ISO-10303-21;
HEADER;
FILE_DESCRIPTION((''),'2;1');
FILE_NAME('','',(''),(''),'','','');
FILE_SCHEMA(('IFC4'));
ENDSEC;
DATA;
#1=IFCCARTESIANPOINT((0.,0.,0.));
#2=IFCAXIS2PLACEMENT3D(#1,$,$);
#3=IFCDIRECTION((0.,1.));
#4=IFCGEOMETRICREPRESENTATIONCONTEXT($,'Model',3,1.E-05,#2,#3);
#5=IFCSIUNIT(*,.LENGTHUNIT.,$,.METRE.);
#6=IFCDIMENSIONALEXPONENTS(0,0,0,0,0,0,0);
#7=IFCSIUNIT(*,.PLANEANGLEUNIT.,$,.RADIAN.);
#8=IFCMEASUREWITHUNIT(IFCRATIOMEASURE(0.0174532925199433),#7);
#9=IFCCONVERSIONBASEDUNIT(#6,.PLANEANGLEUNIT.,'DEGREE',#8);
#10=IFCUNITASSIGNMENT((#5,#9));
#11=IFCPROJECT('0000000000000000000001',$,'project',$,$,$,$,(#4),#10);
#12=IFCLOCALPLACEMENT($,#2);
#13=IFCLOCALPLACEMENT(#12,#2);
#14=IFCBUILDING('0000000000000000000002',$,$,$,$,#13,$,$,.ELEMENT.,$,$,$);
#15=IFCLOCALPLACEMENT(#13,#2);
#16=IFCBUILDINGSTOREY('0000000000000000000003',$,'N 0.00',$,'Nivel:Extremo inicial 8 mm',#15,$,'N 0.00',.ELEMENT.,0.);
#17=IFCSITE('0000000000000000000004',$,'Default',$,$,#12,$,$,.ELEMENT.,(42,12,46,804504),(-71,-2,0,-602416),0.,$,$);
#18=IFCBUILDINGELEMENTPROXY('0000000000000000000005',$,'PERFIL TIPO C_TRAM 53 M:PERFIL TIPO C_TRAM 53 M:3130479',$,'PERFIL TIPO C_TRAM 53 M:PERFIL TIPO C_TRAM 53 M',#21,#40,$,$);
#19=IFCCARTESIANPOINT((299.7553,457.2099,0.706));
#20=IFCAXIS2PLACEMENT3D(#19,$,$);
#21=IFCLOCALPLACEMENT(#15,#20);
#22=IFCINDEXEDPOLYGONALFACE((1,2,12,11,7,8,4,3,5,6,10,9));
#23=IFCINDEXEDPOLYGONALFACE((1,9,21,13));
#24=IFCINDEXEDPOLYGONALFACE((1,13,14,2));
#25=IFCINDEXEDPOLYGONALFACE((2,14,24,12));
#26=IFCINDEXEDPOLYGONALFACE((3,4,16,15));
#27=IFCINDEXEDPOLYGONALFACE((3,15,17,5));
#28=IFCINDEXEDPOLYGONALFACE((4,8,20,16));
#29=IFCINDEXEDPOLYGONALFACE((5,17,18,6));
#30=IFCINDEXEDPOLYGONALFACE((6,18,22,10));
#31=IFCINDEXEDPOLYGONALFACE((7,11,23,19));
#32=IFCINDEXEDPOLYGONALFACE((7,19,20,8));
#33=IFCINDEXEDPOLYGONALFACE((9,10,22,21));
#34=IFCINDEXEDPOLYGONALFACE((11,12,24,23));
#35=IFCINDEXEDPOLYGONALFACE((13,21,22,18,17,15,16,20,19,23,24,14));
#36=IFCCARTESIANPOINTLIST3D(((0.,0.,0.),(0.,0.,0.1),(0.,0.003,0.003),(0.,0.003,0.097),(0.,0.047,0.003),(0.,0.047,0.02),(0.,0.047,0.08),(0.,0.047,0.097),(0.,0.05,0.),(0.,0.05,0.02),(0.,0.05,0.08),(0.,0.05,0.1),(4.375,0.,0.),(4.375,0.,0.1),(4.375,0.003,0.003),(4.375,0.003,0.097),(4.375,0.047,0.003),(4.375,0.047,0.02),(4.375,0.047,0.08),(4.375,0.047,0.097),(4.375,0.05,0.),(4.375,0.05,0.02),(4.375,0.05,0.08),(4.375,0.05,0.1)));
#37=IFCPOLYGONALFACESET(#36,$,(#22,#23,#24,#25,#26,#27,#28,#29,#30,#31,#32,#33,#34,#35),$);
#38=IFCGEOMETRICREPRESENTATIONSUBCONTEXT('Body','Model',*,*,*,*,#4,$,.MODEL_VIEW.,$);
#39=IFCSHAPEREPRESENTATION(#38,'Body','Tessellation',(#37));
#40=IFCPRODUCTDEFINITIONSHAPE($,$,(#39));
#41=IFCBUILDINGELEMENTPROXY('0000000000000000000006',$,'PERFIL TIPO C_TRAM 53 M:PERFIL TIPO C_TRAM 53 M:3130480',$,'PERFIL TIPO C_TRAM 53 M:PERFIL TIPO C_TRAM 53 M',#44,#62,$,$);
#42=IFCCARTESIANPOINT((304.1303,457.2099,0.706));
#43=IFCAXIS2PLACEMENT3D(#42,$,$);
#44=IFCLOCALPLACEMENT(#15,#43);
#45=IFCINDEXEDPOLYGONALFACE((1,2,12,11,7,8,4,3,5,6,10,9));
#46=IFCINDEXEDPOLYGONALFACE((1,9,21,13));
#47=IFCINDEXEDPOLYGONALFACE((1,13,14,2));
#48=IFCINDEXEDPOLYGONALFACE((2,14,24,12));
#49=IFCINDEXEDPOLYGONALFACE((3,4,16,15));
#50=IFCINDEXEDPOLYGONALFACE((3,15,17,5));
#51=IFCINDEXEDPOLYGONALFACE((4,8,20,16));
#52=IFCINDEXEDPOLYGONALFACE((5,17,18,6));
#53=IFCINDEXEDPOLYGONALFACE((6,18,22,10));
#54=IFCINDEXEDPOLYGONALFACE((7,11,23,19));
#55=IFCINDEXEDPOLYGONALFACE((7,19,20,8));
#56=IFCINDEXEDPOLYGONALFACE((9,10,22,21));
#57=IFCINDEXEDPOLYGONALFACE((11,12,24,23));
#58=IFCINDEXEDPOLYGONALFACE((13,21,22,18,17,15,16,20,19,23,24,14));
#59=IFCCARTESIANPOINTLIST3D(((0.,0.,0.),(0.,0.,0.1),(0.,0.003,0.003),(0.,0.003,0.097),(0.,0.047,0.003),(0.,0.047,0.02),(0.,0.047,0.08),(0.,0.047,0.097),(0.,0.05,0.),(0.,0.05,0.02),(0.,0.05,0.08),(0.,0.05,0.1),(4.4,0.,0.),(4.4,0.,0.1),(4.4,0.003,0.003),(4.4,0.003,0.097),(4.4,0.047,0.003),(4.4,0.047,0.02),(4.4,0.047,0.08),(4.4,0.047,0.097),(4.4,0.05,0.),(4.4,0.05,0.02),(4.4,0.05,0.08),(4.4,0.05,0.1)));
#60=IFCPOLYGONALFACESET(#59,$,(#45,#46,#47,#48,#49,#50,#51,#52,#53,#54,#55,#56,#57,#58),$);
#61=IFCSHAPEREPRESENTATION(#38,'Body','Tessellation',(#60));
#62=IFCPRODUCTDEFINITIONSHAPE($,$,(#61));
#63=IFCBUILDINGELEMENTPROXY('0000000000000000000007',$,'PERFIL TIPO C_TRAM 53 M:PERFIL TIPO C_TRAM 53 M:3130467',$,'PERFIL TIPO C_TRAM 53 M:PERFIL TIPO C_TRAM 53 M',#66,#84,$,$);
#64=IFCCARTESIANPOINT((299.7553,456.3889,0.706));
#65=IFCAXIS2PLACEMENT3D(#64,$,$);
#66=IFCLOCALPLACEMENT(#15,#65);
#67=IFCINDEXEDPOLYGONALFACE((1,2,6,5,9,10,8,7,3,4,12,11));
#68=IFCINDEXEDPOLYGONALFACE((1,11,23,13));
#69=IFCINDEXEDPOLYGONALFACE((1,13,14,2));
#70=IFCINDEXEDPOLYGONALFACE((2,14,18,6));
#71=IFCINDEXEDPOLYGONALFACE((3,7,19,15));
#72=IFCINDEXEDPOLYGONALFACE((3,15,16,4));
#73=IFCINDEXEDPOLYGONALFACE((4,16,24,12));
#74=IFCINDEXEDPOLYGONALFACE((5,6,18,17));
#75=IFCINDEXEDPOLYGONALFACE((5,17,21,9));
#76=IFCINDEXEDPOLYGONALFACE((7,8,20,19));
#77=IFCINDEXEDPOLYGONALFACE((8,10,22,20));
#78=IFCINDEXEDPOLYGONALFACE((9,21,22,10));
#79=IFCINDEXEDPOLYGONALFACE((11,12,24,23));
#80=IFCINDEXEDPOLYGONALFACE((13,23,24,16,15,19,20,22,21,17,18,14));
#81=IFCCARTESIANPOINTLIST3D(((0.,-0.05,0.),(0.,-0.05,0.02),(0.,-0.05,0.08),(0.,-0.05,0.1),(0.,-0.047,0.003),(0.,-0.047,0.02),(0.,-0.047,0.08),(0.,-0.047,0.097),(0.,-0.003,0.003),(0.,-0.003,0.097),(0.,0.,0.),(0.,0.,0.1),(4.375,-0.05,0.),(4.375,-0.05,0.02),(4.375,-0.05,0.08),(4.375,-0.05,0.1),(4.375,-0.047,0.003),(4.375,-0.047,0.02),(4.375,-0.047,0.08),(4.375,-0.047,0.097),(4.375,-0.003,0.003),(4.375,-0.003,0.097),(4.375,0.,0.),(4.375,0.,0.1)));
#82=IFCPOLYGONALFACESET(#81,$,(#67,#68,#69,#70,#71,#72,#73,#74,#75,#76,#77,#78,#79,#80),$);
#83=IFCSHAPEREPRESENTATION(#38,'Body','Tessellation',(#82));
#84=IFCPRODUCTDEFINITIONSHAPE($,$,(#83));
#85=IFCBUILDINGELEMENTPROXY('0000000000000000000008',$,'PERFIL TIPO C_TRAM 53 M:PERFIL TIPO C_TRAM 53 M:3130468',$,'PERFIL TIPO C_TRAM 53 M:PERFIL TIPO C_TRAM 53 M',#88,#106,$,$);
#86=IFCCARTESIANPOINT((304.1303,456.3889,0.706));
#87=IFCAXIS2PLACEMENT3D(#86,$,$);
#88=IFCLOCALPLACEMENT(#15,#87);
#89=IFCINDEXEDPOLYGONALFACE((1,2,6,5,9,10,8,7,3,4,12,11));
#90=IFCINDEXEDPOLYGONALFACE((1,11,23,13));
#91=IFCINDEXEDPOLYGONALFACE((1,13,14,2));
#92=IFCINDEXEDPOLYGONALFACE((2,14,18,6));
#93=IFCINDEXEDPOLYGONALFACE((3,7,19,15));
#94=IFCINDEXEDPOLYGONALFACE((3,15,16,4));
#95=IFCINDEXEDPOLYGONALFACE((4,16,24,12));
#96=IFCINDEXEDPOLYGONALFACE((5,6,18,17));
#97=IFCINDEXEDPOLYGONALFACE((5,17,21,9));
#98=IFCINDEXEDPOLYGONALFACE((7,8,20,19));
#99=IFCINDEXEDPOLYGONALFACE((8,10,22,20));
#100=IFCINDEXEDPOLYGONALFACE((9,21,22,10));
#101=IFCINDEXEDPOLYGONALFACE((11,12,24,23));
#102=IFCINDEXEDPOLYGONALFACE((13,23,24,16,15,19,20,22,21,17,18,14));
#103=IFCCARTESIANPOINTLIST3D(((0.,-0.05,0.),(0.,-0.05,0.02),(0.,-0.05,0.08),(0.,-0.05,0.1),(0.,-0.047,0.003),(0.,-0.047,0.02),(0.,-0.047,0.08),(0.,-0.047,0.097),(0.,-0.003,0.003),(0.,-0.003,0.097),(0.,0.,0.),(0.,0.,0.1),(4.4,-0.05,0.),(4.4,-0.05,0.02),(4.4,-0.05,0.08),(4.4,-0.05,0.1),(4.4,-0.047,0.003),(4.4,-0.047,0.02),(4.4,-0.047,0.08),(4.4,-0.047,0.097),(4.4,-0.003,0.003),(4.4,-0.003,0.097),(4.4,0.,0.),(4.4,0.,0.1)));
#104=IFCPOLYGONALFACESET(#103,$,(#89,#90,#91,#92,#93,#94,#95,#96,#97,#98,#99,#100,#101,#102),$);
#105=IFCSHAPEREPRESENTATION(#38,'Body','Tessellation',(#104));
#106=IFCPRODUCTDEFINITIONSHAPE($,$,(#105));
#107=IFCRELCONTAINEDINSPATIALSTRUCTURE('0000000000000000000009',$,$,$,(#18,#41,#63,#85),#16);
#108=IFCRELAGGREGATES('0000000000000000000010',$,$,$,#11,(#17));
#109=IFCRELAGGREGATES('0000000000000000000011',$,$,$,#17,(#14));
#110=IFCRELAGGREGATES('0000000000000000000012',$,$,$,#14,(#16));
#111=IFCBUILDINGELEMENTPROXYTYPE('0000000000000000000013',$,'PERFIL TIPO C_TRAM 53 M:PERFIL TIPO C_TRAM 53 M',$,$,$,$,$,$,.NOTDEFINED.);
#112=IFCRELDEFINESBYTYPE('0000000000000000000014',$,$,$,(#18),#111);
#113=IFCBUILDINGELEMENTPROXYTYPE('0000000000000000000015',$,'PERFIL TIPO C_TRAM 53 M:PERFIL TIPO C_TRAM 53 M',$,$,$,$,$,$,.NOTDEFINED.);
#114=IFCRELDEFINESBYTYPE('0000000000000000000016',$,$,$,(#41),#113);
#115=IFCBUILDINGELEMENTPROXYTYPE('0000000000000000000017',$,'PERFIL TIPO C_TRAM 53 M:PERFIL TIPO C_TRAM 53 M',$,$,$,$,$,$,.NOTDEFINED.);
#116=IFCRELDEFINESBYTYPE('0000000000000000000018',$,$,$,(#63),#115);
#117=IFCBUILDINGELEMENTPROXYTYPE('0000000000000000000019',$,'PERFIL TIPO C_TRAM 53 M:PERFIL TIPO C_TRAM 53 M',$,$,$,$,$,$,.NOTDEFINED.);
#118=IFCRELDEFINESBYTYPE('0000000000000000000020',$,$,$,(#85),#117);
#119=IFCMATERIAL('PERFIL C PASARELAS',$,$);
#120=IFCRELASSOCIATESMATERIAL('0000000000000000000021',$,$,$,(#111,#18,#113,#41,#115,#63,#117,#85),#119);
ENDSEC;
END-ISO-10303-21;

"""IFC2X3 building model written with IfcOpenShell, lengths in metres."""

from ifc_helpers import new_model, entity, si_unit, converted_unit, direction, frame, origin, place, context, subcontext, project, spatial, polyline, outline, extrude, source, transform, mapped, material, type_object, type_shapes, element, save


model = new_model("IFC2X3")

# Units and contexts
model_context = context("Model", 3, precision=1e-05, world=origin(), true_north=direction((0.0, 1.0)))
body_context = subcontext(model_context, "Body", "Model", "MODEL_VIEW")
ifc_project = project(units=[si_unit("LENGTHUNIT", "METRE"), converted_unit("PLANEANGLEUNIT", "DEGREE", entity("IfcRatioMeasure", 0.0174532925199433), si_unit("PLANEANGLEUNIT", "RADIAN"), dimensions=[0, 0, 0, 0, 0, 0, 0])], contexts=[model_context])

# Site, building, storey
site_placement = place(None, origin())
site = spatial("IfcSite", under=ifc_project, at=site_placement, Name="Default", CompositionType="ELEMENT", RefLatitude=(42, 12, 46, 804504), RefLongitude=(-71, -2, 0, -602416), RefElevation=0.0)
building_placement = place(site_placement, origin())
building = spatial("IfcBuilding", under=site, at=building_placement, CompositionType="ELEMENT")
storey_placement = place(building_placement, origin())
storey = spatial("IfcBuildingStorey", under=building, at=storey_placement, Name="N 0.00", ObjectType="Nivel:Extremo inicial 8 mm", LongName="N 0.00", CompositionType="ELEMENT", Elevation=0.0)

# Building element proxies
ifc_material_1 = material(Name="PERFIL C PASARELAS")
building_element_proxy_type_1 = type_object("IfcBuildingElementProxyType", Name="PERFIL TIPO C_TRAM 53 M:PERFIL TIPO C_TRAM 53 M", PredefinedType="NOTDEFINED", material=ifc_material_1)
shared_shape_1 = source(origin(), body_context, "Body", "SweptSolid", [
    extrude(outline(polyline([(-0.0172, 0.03), (-0.0142, 0.03), (-0.0142, 0.047), (0.0298, 0.047), (0.0298, -0.047), (-0.0142, -0.047), (-0.0142, -0.03), (-0.0172, -0.03), (-0.0172, -0.05), (0.0328, -0.05), (0.0328, 0.05), (-0.0172, 0.05), (-0.0172, 0.03)])), frame((0.0, 0.0328, 0.05), z_axis=(1.0, 0.0, 0.0), x_axis=(0.0, -1.0, 0.0)), (0.0, 0.0, 1.0), 4.375),
])
type_shapes(building_element_proxy_type_1, [shared_shape_1])
proxy_1_placement = place(storey_placement, frame((299.7553, 457.2099, 0.706)))
element("IfcBuildingElementProxy", 1, at=proxy_1_placement, inside=storey, type_object=building_element_proxy_type_1, material=ifc_material_1, Name="PERFIL TIPO C_TRAM 53 M:PERFIL TIPO C_TRAM 53 M:3130479", ObjectType="PERFIL TIPO C_TRAM 53 M:PERFIL TIPO C_TRAM 53 M", context=body_context, shape_type="MappedRepresentation", body=[
    mapped(shared_shape_1, transform((0.0, 0.0, 0.0), scale=1.0)),
])
building_element_proxy_type_2 = type_object("IfcBuildingElementProxyType", Name="PERFIL TIPO C_TRAM 53 M:PERFIL TIPO C_TRAM 53 M", PredefinedType="NOTDEFINED", material=ifc_material_1)
shared_shape_2 = source(origin(), body_context, "Body", "SweptSolid", [
    extrude(outline(polyline([(-0.0172, 0.03), (-0.0142, 0.03), (-0.0142, 0.047), (0.0298, 0.047), (0.0298, -0.047), (-0.0142, -0.047), (-0.0142, -0.03), (-0.0172, -0.03), (-0.0172, -0.05), (0.0328, -0.05), (0.0328, 0.05), (-0.0172, 0.05), (-0.0172, 0.03)])), frame((0.0, 0.0328, 0.05), z_axis=(1.0, 0.0, 0.0), x_axis=(0.0, -1.0, 0.0)), (0.0, 0.0, 1.0), 4.4),
])
type_shapes(building_element_proxy_type_2, [shared_shape_2])
proxy_2_placement = place(storey_placement, frame((304.1303, 457.2099, 0.706)))
element("IfcBuildingElementProxy", 2, at=proxy_2_placement, inside=storey, type_object=building_element_proxy_type_2, material=ifc_material_1, Name="PERFIL TIPO C_TRAM 53 M:PERFIL TIPO C_TRAM 53 M:3130480", ObjectType="PERFIL TIPO C_TRAM 53 M:PERFIL TIPO C_TRAM 53 M", context=body_context, shape_type="MappedRepresentation", body=[
    mapped(shared_shape_2, transform((0.0, 0.0, 0.0), scale=1.0)),
])
building_element_proxy_type_3 = type_object("IfcBuildingElementProxyType", Name="PERFIL TIPO C_TRAM 53 M:PERFIL TIPO C_TRAM 53 M", PredefinedType="NOTDEFINED", material=ifc_material_1)
shared_shape_3 = source(origin(), body_context, "Body", "SweptSolid", [
    extrude(outline(polyline([(0.03, -0.0172), (0.05, -0.0172), (0.05, 0.0328), (-0.05, 0.0328), (-0.05, -0.0172), (-0.03, -0.0172), (-0.03, -0.0142), (-0.047, -0.0142), (-0.047, 0.0298), (0.047, 0.0298), (0.047, -0.0142), (0.03, -0.0142), (0.03, -0.0172)])), frame((0.0, -0.0328, 0.05), z_axis=(1.0, 0.0, 0.0), x_axis=(0.0, 0.0, -1.0)), (0.0, 0.0, 1.0), 4.375),
])
type_shapes(building_element_proxy_type_3, [shared_shape_3])
proxy_3_placement = place(storey_placement, frame((299.7553, 456.3889, 0.706)))
element("IfcBuildingElementProxy", 3, at=proxy_3_placement, inside=storey, type_object=building_element_proxy_type_3, material=ifc_material_1, Name="PERFIL TIPO C_TRAM 53 M:PERFIL TIPO C_TRAM 53 M:3130467", ObjectType="PERFIL TIPO C_TRAM 53 M:PERFIL TIPO C_TRAM 53 M", context=body_context, shape_type="MappedRepresentation", body=[
    mapped(shared_shape_3, transform((0.0, 0.0, 0.0), scale=1.0)),
])
building_element_proxy_type_4 = type_object("IfcBuildingElementProxyType", Name="PERFIL TIPO C_TRAM 53 M:PERFIL TIPO C_TRAM 53 M", PredefinedType="NOTDEFINED", material=ifc_material_1)
shared_shape_4 = source(origin(), body_context, "Body", "SweptSolid", [
    extrude(outline(polyline([(0.03, -0.0172), (0.05, -0.0172), (0.05, 0.0328), (-0.05, 0.0328), (-0.05, -0.0172), (-0.03, -0.0172), (-0.03, -0.0142), (-0.047, -0.0142), (-0.047, 0.0298), (0.047, 0.0298), (0.047, -0.0142), (0.03, -0.0142), (0.03, -0.0172)])), frame((0.0, -0.0328, 0.05), z_axis=(1.0, 0.0, 0.0), x_axis=(0.0, 0.0, -1.0)), (0.0, 0.0, 1.0), 4.4),
])
type_shapes(building_element_proxy_type_4, [shared_shape_4])
proxy_4_placement = place(storey_placement, frame((304.1303, 456.3889, 0.706)))
element("IfcBuildingElementProxy", 4, at=proxy_4_placement, inside=storey, type_object=building_element_proxy_type_4, material=ifc_material_1, Name="PERFIL TIPO C_TRAM 53 M:PERFIL TIPO C_TRAM 53 M:3130468", ObjectType="PERFIL TIPO C_TRAM 53 M:PERFIL TIPO C_TRAM 53 M", context=body_context, shape_type="MappedRepresentation", body=[
    mapped(shared_shape_4, transform((0.0, 0.0, 0.0), scale=1.0)),
])

save(model, "model.ifc")
